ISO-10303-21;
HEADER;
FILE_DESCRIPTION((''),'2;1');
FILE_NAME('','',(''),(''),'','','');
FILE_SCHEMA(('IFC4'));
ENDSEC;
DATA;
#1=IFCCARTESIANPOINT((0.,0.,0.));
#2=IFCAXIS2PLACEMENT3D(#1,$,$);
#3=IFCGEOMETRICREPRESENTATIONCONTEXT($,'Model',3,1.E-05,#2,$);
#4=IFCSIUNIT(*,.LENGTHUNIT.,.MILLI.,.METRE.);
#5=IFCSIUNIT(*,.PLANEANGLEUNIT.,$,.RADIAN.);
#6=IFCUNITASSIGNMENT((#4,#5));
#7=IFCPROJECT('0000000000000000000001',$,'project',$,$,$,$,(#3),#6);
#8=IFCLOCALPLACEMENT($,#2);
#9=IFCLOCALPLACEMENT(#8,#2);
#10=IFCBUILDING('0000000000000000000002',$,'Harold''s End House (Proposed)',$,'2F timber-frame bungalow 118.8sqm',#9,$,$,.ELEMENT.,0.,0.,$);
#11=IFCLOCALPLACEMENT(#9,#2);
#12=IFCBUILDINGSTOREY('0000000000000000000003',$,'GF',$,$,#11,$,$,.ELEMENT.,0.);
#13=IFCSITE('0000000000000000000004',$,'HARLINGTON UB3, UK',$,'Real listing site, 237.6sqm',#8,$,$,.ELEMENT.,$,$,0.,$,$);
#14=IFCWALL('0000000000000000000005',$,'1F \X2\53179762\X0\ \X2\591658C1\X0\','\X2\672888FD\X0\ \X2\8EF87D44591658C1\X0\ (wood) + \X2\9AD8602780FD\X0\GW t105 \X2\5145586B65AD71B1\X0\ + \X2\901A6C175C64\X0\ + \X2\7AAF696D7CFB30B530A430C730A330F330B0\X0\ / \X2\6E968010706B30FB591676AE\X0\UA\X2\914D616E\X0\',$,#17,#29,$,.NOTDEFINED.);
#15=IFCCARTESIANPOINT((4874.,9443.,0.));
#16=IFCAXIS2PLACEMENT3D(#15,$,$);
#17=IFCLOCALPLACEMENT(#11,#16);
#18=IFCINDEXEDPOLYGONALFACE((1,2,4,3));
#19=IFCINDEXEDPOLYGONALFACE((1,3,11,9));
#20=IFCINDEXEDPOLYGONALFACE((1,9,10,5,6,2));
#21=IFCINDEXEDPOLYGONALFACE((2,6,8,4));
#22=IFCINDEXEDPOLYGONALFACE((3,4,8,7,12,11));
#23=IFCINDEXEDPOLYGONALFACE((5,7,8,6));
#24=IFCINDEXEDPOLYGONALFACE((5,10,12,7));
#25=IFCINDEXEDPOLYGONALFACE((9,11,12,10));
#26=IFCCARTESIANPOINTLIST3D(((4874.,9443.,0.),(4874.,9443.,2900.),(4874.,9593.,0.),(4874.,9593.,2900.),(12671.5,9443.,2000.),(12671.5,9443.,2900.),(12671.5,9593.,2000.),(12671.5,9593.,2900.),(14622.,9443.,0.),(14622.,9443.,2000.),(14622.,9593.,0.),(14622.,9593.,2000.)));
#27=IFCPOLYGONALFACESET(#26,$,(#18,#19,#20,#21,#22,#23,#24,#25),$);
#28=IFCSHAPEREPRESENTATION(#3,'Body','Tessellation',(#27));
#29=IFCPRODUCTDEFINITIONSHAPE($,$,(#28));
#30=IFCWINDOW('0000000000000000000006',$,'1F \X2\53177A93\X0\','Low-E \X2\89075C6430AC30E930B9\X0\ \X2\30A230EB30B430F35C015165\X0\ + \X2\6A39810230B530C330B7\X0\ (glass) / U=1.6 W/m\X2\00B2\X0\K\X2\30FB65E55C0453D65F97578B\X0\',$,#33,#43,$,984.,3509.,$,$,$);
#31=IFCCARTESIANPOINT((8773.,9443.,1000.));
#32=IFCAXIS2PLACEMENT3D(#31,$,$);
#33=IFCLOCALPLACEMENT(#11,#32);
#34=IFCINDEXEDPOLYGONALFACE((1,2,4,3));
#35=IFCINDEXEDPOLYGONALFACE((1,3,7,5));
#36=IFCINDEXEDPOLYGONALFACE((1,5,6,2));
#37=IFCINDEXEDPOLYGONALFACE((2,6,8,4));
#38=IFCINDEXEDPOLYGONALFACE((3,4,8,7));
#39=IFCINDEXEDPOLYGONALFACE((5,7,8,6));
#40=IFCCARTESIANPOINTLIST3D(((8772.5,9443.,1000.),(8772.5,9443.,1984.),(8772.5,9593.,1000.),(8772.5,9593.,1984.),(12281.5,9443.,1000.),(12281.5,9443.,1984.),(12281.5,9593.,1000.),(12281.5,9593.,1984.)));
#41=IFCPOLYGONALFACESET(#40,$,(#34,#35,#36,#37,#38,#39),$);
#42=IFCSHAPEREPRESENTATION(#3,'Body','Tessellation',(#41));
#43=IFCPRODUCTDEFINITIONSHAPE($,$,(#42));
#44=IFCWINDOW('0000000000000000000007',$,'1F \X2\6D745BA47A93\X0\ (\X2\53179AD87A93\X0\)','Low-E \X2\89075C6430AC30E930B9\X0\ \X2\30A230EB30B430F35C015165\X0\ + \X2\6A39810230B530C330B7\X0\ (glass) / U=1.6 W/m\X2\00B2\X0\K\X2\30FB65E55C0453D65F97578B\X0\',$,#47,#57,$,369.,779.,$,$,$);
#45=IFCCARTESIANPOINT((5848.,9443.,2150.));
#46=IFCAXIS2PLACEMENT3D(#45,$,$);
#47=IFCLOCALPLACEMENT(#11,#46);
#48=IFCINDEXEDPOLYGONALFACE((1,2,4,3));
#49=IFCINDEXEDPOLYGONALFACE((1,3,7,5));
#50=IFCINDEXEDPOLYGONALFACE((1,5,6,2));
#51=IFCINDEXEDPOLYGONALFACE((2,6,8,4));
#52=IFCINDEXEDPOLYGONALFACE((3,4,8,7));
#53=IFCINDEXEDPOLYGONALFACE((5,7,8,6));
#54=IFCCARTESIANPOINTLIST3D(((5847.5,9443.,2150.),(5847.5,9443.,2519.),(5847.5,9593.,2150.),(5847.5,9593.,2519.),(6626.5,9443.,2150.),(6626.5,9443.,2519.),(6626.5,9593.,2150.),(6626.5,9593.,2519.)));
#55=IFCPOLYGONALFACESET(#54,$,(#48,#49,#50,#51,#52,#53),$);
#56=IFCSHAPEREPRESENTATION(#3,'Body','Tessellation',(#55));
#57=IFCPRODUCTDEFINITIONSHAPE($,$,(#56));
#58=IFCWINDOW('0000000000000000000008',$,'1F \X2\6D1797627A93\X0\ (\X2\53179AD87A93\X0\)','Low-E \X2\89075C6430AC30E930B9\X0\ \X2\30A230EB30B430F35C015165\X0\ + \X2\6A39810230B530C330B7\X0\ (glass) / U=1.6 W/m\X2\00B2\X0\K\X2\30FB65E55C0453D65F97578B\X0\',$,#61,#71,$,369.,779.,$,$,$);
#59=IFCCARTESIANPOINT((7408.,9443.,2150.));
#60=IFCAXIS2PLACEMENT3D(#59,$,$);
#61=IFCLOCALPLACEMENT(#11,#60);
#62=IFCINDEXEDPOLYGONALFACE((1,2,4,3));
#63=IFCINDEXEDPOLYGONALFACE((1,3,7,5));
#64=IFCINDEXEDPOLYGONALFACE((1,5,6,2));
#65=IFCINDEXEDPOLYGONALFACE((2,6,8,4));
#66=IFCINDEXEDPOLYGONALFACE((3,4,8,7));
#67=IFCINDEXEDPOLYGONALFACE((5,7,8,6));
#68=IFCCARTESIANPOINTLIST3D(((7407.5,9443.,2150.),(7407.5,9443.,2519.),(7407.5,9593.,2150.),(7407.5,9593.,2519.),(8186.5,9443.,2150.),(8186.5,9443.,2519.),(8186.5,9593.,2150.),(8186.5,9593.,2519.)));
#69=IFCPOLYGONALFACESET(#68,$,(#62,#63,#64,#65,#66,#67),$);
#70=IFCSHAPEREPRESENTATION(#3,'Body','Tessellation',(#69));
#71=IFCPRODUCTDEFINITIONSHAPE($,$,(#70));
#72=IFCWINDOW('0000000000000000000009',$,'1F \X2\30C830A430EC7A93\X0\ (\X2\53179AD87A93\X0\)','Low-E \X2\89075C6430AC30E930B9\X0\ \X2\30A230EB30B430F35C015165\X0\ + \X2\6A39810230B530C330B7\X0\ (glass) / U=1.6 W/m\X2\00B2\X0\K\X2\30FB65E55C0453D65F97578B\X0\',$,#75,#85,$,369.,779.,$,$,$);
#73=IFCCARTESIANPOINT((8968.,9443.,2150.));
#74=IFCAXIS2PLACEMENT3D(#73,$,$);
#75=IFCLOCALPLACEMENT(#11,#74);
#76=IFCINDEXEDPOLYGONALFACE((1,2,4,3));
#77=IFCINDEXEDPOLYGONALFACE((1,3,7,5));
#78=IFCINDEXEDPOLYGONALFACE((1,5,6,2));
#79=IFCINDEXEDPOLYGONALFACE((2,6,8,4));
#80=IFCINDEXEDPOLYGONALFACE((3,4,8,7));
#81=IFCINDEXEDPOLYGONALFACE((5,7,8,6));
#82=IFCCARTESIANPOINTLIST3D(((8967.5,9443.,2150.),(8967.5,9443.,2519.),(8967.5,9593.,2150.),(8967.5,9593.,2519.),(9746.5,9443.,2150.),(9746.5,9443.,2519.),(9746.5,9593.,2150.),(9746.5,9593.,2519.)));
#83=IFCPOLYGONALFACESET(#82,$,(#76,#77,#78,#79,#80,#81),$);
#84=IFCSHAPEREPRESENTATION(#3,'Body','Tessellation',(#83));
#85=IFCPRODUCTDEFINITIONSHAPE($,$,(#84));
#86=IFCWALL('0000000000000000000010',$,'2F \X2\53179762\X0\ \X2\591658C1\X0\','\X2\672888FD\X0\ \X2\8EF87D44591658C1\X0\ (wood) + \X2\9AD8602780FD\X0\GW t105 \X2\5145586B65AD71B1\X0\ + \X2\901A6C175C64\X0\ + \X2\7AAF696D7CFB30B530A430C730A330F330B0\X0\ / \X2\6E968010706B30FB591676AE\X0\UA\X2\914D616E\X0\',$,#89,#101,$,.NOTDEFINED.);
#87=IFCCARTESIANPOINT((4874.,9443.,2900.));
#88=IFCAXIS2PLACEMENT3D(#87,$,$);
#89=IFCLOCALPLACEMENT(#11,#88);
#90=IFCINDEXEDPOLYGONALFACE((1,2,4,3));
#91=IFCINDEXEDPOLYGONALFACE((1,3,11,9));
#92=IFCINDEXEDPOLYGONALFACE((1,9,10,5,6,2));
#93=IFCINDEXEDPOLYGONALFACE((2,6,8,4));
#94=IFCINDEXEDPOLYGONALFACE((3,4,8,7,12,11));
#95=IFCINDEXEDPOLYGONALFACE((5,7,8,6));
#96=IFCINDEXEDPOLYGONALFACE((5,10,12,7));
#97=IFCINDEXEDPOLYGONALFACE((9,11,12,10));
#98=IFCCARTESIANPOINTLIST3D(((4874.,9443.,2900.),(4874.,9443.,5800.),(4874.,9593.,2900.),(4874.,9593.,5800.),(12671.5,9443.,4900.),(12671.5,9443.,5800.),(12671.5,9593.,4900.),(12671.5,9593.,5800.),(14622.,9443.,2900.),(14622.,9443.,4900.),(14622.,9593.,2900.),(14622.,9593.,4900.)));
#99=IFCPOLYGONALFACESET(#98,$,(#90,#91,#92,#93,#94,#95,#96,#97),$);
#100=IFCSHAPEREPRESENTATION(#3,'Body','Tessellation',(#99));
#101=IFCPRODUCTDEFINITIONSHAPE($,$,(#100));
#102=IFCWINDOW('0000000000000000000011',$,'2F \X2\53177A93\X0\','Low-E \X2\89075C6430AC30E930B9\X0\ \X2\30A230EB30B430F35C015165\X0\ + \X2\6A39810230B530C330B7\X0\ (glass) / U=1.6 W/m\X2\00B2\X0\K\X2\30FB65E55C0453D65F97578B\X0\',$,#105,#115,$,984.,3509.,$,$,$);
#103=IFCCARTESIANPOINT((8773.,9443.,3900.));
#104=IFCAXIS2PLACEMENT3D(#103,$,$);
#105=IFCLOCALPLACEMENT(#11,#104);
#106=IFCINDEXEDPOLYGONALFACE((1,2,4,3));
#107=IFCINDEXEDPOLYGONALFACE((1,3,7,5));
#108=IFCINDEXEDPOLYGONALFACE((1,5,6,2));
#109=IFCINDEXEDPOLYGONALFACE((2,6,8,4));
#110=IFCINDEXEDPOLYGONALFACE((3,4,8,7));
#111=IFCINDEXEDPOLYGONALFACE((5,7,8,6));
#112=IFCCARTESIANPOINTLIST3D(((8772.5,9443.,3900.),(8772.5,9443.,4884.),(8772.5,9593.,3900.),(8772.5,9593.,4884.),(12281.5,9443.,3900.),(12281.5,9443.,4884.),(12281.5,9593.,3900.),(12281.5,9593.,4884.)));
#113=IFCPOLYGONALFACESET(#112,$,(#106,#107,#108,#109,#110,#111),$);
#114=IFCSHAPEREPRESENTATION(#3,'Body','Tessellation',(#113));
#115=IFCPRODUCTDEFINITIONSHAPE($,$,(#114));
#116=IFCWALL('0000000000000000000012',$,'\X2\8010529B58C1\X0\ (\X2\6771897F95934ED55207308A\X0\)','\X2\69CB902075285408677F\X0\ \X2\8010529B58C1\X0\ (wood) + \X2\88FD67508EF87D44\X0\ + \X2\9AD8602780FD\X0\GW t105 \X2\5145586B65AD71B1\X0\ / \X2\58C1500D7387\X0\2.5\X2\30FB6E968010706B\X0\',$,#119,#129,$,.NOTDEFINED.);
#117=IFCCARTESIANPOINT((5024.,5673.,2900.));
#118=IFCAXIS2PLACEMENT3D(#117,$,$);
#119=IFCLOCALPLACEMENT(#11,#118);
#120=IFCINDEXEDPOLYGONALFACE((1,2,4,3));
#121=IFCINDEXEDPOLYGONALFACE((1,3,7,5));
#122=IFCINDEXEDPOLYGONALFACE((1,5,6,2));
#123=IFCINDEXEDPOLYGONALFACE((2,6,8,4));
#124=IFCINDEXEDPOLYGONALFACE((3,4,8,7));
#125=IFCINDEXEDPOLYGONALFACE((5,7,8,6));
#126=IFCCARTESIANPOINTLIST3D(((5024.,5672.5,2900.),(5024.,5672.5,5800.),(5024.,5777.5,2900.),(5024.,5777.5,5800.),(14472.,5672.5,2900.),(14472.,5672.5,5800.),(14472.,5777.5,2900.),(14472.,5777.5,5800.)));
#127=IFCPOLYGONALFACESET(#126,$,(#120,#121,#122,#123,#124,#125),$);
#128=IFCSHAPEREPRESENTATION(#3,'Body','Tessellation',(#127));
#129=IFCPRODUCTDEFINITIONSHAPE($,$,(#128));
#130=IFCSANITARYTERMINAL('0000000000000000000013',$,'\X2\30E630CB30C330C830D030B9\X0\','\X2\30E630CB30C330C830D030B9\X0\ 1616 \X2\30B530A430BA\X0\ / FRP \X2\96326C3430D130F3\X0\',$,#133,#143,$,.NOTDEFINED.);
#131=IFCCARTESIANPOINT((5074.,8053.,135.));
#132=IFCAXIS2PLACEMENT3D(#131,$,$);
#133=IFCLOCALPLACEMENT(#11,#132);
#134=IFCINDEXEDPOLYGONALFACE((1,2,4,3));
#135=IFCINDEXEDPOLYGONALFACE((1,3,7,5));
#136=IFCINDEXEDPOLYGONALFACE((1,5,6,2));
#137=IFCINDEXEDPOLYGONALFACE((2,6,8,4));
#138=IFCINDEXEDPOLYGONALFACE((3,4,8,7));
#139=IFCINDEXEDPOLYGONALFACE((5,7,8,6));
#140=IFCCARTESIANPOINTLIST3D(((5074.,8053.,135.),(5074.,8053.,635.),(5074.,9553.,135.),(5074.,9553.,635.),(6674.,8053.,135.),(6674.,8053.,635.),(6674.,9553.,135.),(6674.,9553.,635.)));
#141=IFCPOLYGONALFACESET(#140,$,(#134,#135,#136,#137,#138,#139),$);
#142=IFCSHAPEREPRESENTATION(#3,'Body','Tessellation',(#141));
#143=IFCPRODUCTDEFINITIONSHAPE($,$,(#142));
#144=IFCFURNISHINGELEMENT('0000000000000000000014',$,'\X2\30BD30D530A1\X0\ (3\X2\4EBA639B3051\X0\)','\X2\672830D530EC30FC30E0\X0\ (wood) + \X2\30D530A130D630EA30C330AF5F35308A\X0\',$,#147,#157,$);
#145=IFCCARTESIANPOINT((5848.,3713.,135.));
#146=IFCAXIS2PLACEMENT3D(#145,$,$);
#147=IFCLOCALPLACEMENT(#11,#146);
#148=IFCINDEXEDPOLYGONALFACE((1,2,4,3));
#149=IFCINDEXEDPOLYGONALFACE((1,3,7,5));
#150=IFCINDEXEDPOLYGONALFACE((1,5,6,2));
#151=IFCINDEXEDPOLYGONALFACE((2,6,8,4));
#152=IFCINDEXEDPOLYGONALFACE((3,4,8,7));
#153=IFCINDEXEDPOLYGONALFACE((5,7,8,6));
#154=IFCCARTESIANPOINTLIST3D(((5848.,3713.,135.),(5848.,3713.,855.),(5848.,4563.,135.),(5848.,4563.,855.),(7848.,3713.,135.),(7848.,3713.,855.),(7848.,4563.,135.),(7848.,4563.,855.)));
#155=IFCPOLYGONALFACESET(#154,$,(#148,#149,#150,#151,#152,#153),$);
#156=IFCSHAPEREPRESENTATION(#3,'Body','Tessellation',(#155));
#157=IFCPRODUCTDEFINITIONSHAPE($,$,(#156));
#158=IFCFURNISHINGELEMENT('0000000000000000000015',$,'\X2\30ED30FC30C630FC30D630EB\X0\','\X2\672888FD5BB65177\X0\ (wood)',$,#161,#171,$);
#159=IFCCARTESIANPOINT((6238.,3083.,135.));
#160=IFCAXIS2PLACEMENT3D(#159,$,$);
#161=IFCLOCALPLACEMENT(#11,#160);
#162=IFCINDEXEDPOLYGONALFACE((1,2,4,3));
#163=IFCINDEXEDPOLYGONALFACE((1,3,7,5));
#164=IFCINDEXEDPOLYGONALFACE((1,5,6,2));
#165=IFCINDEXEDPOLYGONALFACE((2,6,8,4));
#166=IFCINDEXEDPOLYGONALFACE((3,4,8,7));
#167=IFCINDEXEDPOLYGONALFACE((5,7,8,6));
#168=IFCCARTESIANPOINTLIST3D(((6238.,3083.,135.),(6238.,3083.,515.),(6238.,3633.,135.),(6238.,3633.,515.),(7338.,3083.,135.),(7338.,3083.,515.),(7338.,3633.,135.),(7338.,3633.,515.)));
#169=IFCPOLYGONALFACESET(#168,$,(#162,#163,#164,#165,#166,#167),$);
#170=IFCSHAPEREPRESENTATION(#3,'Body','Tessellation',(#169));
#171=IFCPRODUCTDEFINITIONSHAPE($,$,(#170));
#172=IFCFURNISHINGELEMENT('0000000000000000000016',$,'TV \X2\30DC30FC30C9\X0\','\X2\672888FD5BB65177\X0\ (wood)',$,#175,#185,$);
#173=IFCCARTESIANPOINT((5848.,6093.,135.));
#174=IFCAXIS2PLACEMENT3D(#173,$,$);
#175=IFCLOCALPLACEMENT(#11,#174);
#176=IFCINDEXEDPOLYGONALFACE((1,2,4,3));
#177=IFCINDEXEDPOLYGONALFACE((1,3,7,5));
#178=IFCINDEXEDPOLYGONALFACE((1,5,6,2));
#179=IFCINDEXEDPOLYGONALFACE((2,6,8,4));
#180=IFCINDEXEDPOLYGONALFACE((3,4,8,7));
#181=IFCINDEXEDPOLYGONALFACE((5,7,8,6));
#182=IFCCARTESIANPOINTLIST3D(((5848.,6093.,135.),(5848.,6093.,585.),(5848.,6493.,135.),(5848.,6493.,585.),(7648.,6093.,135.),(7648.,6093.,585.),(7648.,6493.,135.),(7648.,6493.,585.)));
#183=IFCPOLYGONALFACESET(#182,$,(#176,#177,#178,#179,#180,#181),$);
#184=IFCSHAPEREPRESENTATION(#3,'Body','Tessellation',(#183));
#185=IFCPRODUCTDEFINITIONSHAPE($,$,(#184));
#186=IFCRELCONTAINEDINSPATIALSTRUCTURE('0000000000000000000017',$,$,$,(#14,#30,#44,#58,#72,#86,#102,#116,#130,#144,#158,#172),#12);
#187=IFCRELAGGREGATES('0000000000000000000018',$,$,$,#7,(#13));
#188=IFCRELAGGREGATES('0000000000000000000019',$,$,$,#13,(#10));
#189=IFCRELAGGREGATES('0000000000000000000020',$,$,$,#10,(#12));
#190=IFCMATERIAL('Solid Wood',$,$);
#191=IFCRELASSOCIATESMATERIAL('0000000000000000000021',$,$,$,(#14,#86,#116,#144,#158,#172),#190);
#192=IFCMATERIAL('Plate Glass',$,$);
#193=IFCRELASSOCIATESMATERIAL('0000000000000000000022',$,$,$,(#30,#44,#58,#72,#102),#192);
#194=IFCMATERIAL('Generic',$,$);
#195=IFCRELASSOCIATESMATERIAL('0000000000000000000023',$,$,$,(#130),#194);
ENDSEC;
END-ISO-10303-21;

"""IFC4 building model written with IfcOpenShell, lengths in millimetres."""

from ifc_helpers import new_model, si_unit, frame, frame_2d, origin, place, context, project, spatial, rectangle, extrude, material, element, fill, save


model = new_model("IFC4")

# Units and contexts
model_context = context("Model", 3, precision=1e-05, world=origin())
ifc_project = project(units=[si_unit("LENGTHUNIT", "METRE", prefix="MILLI"), si_unit("PLANEANGLEUNIT", "RADIAN")], contexts=[model_context])

# Site, building, storey
site_placement = place(None, origin())
site = spatial("IfcSite", under=ifc_project, at=site_placement, Name="HARLINGTON UB3, UK", ObjectType="Real listing site, 237.6sqm", CompositionType="ELEMENT", RefElevation=0.0)
building_placement = place(site_placement, origin())
building = spatial("IfcBuilding", under=site, at=building_placement, Name="Harold's End House (Proposed)", ObjectType="2F timber-frame bungalow 118.8sqm", CompositionType="ELEMENT", ElevationOfRefHeight=0.0, ElevationOfTerrain=0.0)
storey_placement = place(building_placement, origin())
storey = spatial("IfcBuildingStorey", under=building, at=storey_placement, Name="GF", CompositionType="ELEMENT", Elevation=0.0)

# Wall, openings, windows
ifc_material_1 = material(Name="Solid Wood")
wall_1_placement = place(storey_placement, frame((4874.0, 9443.0, 0.0)))
wall_1 = element("IfcWall", 1, at=wall_1_placement, inside=storey, material=ifc_material_1, Name="1F 北面 外壁", Description="木製 軸組外壁 (wood) + 高性能GW t105 充填断熱 + 通気層 + 窯業系サイディング / 準耐火・外皮UA配慮", PredefinedType="NOTDEFINED", context=model_context, shape_type="SweptSolid", body=[
    extrude(rectangle(XDim=9748.0, YDim=150.0, at=frame_2d((4874.0, 75.0))), frame((4874.0, 9443.0, 0.0)), (0.0, 0.0, 1.0), 2900.0),
])
opening_1_placement = place(storey_placement, frame((8773.0, 9443.0, 1000.0)))
opening_1 = element("IfcOpeningElement", 2, at=opening_1_placement, cuts=wall_1, PredefinedType="NOTDEFINED", context=model_context, shape_type="SweptSolid", body=[
    extrude(rectangle(XDim=3509.0, YDim=150.0, at=frame_2d((1754.0, 75.0))), frame((8773.0, 9443.0, 1000.0)), (0.0, 0.0, 1.0), 984.0),
])
opening_2_placement = place(storey_placement, frame((5848.0, 9443.0, 2150.0)))
opening_2 = element("IfcOpeningElement", 3, at=opening_2_placement, cuts=wall_1, PredefinedType="NOTDEFINED", context=model_context, shape_type="SweptSolid", body=[
    extrude(rectangle(XDim=779.0, YDim=150.0, at=frame_2d((389.0, 75.0))), frame((5848.0, 9443.0, 2150.0)), (0.0, 0.0, 1.0), 369.0),
])
opening_3_placement = place(storey_placement, frame((7408.0, 9443.0, 2150.0)))
opening_3 = element("IfcOpeningElement", 4, at=opening_3_placement, cuts=wall_1, PredefinedType="NOTDEFINED", context=model_context, shape_type="SweptSolid", body=[
    extrude(rectangle(XDim=779.0, YDim=150.0, at=frame_2d((389.0, 75.0))), frame((7408.0, 9443.0, 2150.0)), (0.0, 0.0, 1.0), 369.0),
])
opening_4_placement = place(storey_placement, frame((8968.0, 9443.0, 2150.0)))
opening_4 = element("IfcOpeningElement", 5, at=opening_4_placement, cuts=wall_1, PredefinedType="NOTDEFINED", context=model_context, shape_type="SweptSolid", body=[
    extrude(rectangle(XDim=779.0, YDim=150.0, at=frame_2d((389.0, 75.0))), frame((8968.0, 9443.0, 2150.0)), (0.0, 0.0, 1.0), 369.0),
])
ifc_material_2 = material(Name="Plate Glass")
window_1_placement = place(storey_placement, frame((8773.0, 9443.0, 1000.0)))
window_1 = element("IfcWindow", 6, at=window_1_placement, inside=storey, material=ifc_material_2, Name="1F 北窓", Description="Low-E 複層ガラス アルゴン封入 + 樹脂サッシ (glass) / U=1.6 W/m²K・日射取得型", OverallHeight=984.0, OverallWidth=3509.0, context=model_context, shape_type="SweptSolid", body=[
    extrude(rectangle(XDim=3509.0, YDim=150.0, at=frame_2d((1754.0, 75.0))), frame((8773.0, 9443.0, 1000.0)), (0.0, 0.0, 1.0), 984.0),
])
fill(opening_1, window_1)
window_2_placement = place(storey_placement, frame((5848.0, 9443.0, 2150.0)))
window_2 = element("IfcWindow", 7, at=window_2_placement, inside=storey, material=ifc_material_2, Name="1F 浴室窓 (北高窓)", Description="Low-E 複層ガラス アルゴン封入 + 樹脂サッシ (glass) / U=1.6 W/m²K・日射取得型", OverallHeight=369.0, OverallWidth=779.0, context=model_context, shape_type="SweptSolid", body=[
    extrude(rectangle(XDim=779.0, YDim=150.0, at=frame_2d((389.0, 75.0))), frame((5848.0, 9443.0, 2150.0)), (0.0, 0.0, 1.0), 369.0),
])
fill(opening_2, window_2)
window_3_placement = place(storey_placement, frame((7408.0, 9443.0, 2150.0)))
window_3 = element("IfcWindow", 8, at=window_3_placement, inside=storey, material=ifc_material_2, Name="1F 洗面窓 (北高窓)", Description="Low-E 複層ガラス アルゴン封入 + 樹脂サッシ (glass) / U=1.6 W/m²K・日射取得型", OverallHeight=369.0, OverallWidth=779.0, context=model_context, shape_type="SweptSolid", body=[
    extrude(rectangle(XDim=779.0, YDim=150.0, at=frame_2d((389.0, 75.0))), frame((7408.0, 9443.0, 2150.0)), (0.0, 0.0, 1.0), 369.0),
])
fill(opening_3, window_3)
window_4_placement = place(storey_placement, frame((8968.0, 9443.0, 2150.0)))
window_4 = element("IfcWindow", 9, at=window_4_placement, inside=storey, material=ifc_material_2, Name="1F トイレ窓 (北高窓)", Description="Low-E 複層ガラス アルゴン封入 + 樹脂サッシ (glass) / U=1.6 W/m²K・日射取得型", OverallHeight=369.0, OverallWidth=779.0, context=model_context, shape_type="SweptSolid", body=[
    extrude(rectangle(XDim=779.0, YDim=150.0, at=frame_2d((389.0, 75.0))), frame((8968.0, 9443.0, 2150.0)), (0.0, 0.0, 1.0), 369.0),
])
fill(opening_4, window_4)

# Wall, opening, window
wall_2_placement = place(storey_placement, frame((4874.0, 9443.0, 2900.0)))
wall_2 = element("IfcWall", 10, at=wall_2_placement, inside=storey, material=ifc_material_1, Name="2F 北面 外壁", Description="木製 軸組外壁 (wood) + 高性能GW t105 充填断熱 + 通気層 + 窯業系サイディング / 準耐火・外皮UA配慮", PredefinedType="NOTDEFINED", context=model_context, shape_type="SweptSolid", body=[
    extrude(rectangle(XDim=9748.0, YDim=150.0, at=frame_2d((4874.0, 75.0))), frame((4874.0, 9443.0, 2900.0)), (0.0, 0.0, 1.0), 2900.0),
])
opening_5_placement = place(storey_placement, frame((8773.0, 9443.0, 3900.0)))
opening_5 = element("IfcOpeningElement", 11, at=opening_5_placement, cuts=wall_2, PredefinedType="NOTDEFINED", context=model_context, shape_type="SweptSolid", body=[
    extrude(rectangle(XDim=3509.0, YDim=150.0, at=frame_2d((1754.0, 75.0))), frame((8773.0, 9443.0, 3900.0)), (0.0, 0.0, 1.0), 984.0),
])
window_5_placement = place(storey_placement, frame((8773.0, 9443.0, 3900.0)))
window_5 = element("IfcWindow", 12, at=window_5_placement, inside=storey, material=ifc_material_2, Name="2F 北窓", Description="Low-E 複層ガラス アルゴン封入 + 樹脂サッシ (glass) / U=1.6 W/m²K・日射取得型", OverallHeight=984.0, OverallWidth=3509.0, context=model_context, shape_type="SweptSolid", body=[
    extrude(rectangle(XDim=3509.0, YDim=150.0, at=frame_2d((1754.0, 75.0))), frame((8773.0, 9443.0, 3900.0)), (0.0, 0.0, 1.0), 984.0),
])
fill(opening_5, window_5)

# Wall
wall_3_placement = place(storey_placement, frame((5024.0, 5673.0, 2900.0)))
element("IfcWall", 13, at=wall_3_placement, inside=storey, material=ifc_material_1, Name="耐力壁 (東西間仕切り)", Description="構造用合板 耐力壁 (wood) + 製材軸組 + 高性能GW t105 充填断熱 / 壁倍率2.5・準耐火", PredefinedType="NOTDEFINED", context=model_context, shape_type="SweptSolid", body=[
    extrude(rectangle(XDim=9448.0, YDim=105.0, at=frame_2d((4724.0, 52.0))), frame((5024.0, 5673.0, 2900.0)), (0.0, 0.0, 1.0), 2900.0),
])

# Sanitary terminal
ifc_material_3 = material(Name="Generic")
sanitary_terminal_placement = place(storey_placement, frame((5074.0, 8053.0, 135.0)))
element("IfcSanitaryTerminal", 14, at=sanitary_terminal_placement, inside=storey, material=ifc_material_3, Name="ユニットバス", Description="ユニットバス 1616 サイズ / FRP 防水パン", PredefinedType="NOTDEFINED", context=model_context, shape_type="SweptSolid", body=[
    extrude(rectangle(XDim=1600.0, YDim=1500.0, at=frame_2d((800.0, 750.0))), frame((5074.0, 8053.0, 135.0)), (0.0, 0.0, 1.0), 500.0),
])

# Furnishing elements
furnishing_1_placement = place(storey_placement, frame((5848.0, 3713.0, 135.0)))
element("IfcFurnishingElement", 15, at=furnishing_1_placement, inside=storey, material=ifc_material_1, Name="ソファ (3人掛け)", Description="木フレーム (wood) + ファブリック張り", context=model_context, shape_type="SweptSolid", body=[
    extrude(rectangle(XDim=2000.0, YDim=850.0, at=frame_2d((1000.0, 425.0))), frame((5848.0, 3713.0, 135.0)), (0.0, 0.0, 1.0), 720.0),
])
furnishing_2_placement = place(storey_placement, frame((6238.0, 3083.0, 135.0)))
element("IfcFurnishingElement", 16, at=furnishing_2_placement, inside=storey, material=ifc_material_1, Name="ローテーブル", Description="木製家具 (wood)", context=model_context, shape_type="SweptSolid", body=[
    extrude(rectangle(XDim=1100.0, YDim=550.0, at=frame_2d((550.0, 275.0))), frame((6238.0, 3083.0, 135.0)), (0.0, 0.0, 1.0), 380.0),
])
furnishing_3_placement = place(storey_placement, frame((5848.0, 6093.0, 135.0)))
element("IfcFurnishingElement", 17, at=furnishing_3_placement, inside=storey, material=ifc_material_1, Name="TV ボード", Description="木製家具 (wood)", context=model_context, shape_type="SweptSolid", body=[
    extrude(rectangle(XDim=1800.0, YDim=400.0, at=frame_2d((900.0, 200.0))), frame((5848.0, 6093.0, 135.0)), (0.0, 0.0, 1.0), 450.0),
])

save(model, "model.ifc")
